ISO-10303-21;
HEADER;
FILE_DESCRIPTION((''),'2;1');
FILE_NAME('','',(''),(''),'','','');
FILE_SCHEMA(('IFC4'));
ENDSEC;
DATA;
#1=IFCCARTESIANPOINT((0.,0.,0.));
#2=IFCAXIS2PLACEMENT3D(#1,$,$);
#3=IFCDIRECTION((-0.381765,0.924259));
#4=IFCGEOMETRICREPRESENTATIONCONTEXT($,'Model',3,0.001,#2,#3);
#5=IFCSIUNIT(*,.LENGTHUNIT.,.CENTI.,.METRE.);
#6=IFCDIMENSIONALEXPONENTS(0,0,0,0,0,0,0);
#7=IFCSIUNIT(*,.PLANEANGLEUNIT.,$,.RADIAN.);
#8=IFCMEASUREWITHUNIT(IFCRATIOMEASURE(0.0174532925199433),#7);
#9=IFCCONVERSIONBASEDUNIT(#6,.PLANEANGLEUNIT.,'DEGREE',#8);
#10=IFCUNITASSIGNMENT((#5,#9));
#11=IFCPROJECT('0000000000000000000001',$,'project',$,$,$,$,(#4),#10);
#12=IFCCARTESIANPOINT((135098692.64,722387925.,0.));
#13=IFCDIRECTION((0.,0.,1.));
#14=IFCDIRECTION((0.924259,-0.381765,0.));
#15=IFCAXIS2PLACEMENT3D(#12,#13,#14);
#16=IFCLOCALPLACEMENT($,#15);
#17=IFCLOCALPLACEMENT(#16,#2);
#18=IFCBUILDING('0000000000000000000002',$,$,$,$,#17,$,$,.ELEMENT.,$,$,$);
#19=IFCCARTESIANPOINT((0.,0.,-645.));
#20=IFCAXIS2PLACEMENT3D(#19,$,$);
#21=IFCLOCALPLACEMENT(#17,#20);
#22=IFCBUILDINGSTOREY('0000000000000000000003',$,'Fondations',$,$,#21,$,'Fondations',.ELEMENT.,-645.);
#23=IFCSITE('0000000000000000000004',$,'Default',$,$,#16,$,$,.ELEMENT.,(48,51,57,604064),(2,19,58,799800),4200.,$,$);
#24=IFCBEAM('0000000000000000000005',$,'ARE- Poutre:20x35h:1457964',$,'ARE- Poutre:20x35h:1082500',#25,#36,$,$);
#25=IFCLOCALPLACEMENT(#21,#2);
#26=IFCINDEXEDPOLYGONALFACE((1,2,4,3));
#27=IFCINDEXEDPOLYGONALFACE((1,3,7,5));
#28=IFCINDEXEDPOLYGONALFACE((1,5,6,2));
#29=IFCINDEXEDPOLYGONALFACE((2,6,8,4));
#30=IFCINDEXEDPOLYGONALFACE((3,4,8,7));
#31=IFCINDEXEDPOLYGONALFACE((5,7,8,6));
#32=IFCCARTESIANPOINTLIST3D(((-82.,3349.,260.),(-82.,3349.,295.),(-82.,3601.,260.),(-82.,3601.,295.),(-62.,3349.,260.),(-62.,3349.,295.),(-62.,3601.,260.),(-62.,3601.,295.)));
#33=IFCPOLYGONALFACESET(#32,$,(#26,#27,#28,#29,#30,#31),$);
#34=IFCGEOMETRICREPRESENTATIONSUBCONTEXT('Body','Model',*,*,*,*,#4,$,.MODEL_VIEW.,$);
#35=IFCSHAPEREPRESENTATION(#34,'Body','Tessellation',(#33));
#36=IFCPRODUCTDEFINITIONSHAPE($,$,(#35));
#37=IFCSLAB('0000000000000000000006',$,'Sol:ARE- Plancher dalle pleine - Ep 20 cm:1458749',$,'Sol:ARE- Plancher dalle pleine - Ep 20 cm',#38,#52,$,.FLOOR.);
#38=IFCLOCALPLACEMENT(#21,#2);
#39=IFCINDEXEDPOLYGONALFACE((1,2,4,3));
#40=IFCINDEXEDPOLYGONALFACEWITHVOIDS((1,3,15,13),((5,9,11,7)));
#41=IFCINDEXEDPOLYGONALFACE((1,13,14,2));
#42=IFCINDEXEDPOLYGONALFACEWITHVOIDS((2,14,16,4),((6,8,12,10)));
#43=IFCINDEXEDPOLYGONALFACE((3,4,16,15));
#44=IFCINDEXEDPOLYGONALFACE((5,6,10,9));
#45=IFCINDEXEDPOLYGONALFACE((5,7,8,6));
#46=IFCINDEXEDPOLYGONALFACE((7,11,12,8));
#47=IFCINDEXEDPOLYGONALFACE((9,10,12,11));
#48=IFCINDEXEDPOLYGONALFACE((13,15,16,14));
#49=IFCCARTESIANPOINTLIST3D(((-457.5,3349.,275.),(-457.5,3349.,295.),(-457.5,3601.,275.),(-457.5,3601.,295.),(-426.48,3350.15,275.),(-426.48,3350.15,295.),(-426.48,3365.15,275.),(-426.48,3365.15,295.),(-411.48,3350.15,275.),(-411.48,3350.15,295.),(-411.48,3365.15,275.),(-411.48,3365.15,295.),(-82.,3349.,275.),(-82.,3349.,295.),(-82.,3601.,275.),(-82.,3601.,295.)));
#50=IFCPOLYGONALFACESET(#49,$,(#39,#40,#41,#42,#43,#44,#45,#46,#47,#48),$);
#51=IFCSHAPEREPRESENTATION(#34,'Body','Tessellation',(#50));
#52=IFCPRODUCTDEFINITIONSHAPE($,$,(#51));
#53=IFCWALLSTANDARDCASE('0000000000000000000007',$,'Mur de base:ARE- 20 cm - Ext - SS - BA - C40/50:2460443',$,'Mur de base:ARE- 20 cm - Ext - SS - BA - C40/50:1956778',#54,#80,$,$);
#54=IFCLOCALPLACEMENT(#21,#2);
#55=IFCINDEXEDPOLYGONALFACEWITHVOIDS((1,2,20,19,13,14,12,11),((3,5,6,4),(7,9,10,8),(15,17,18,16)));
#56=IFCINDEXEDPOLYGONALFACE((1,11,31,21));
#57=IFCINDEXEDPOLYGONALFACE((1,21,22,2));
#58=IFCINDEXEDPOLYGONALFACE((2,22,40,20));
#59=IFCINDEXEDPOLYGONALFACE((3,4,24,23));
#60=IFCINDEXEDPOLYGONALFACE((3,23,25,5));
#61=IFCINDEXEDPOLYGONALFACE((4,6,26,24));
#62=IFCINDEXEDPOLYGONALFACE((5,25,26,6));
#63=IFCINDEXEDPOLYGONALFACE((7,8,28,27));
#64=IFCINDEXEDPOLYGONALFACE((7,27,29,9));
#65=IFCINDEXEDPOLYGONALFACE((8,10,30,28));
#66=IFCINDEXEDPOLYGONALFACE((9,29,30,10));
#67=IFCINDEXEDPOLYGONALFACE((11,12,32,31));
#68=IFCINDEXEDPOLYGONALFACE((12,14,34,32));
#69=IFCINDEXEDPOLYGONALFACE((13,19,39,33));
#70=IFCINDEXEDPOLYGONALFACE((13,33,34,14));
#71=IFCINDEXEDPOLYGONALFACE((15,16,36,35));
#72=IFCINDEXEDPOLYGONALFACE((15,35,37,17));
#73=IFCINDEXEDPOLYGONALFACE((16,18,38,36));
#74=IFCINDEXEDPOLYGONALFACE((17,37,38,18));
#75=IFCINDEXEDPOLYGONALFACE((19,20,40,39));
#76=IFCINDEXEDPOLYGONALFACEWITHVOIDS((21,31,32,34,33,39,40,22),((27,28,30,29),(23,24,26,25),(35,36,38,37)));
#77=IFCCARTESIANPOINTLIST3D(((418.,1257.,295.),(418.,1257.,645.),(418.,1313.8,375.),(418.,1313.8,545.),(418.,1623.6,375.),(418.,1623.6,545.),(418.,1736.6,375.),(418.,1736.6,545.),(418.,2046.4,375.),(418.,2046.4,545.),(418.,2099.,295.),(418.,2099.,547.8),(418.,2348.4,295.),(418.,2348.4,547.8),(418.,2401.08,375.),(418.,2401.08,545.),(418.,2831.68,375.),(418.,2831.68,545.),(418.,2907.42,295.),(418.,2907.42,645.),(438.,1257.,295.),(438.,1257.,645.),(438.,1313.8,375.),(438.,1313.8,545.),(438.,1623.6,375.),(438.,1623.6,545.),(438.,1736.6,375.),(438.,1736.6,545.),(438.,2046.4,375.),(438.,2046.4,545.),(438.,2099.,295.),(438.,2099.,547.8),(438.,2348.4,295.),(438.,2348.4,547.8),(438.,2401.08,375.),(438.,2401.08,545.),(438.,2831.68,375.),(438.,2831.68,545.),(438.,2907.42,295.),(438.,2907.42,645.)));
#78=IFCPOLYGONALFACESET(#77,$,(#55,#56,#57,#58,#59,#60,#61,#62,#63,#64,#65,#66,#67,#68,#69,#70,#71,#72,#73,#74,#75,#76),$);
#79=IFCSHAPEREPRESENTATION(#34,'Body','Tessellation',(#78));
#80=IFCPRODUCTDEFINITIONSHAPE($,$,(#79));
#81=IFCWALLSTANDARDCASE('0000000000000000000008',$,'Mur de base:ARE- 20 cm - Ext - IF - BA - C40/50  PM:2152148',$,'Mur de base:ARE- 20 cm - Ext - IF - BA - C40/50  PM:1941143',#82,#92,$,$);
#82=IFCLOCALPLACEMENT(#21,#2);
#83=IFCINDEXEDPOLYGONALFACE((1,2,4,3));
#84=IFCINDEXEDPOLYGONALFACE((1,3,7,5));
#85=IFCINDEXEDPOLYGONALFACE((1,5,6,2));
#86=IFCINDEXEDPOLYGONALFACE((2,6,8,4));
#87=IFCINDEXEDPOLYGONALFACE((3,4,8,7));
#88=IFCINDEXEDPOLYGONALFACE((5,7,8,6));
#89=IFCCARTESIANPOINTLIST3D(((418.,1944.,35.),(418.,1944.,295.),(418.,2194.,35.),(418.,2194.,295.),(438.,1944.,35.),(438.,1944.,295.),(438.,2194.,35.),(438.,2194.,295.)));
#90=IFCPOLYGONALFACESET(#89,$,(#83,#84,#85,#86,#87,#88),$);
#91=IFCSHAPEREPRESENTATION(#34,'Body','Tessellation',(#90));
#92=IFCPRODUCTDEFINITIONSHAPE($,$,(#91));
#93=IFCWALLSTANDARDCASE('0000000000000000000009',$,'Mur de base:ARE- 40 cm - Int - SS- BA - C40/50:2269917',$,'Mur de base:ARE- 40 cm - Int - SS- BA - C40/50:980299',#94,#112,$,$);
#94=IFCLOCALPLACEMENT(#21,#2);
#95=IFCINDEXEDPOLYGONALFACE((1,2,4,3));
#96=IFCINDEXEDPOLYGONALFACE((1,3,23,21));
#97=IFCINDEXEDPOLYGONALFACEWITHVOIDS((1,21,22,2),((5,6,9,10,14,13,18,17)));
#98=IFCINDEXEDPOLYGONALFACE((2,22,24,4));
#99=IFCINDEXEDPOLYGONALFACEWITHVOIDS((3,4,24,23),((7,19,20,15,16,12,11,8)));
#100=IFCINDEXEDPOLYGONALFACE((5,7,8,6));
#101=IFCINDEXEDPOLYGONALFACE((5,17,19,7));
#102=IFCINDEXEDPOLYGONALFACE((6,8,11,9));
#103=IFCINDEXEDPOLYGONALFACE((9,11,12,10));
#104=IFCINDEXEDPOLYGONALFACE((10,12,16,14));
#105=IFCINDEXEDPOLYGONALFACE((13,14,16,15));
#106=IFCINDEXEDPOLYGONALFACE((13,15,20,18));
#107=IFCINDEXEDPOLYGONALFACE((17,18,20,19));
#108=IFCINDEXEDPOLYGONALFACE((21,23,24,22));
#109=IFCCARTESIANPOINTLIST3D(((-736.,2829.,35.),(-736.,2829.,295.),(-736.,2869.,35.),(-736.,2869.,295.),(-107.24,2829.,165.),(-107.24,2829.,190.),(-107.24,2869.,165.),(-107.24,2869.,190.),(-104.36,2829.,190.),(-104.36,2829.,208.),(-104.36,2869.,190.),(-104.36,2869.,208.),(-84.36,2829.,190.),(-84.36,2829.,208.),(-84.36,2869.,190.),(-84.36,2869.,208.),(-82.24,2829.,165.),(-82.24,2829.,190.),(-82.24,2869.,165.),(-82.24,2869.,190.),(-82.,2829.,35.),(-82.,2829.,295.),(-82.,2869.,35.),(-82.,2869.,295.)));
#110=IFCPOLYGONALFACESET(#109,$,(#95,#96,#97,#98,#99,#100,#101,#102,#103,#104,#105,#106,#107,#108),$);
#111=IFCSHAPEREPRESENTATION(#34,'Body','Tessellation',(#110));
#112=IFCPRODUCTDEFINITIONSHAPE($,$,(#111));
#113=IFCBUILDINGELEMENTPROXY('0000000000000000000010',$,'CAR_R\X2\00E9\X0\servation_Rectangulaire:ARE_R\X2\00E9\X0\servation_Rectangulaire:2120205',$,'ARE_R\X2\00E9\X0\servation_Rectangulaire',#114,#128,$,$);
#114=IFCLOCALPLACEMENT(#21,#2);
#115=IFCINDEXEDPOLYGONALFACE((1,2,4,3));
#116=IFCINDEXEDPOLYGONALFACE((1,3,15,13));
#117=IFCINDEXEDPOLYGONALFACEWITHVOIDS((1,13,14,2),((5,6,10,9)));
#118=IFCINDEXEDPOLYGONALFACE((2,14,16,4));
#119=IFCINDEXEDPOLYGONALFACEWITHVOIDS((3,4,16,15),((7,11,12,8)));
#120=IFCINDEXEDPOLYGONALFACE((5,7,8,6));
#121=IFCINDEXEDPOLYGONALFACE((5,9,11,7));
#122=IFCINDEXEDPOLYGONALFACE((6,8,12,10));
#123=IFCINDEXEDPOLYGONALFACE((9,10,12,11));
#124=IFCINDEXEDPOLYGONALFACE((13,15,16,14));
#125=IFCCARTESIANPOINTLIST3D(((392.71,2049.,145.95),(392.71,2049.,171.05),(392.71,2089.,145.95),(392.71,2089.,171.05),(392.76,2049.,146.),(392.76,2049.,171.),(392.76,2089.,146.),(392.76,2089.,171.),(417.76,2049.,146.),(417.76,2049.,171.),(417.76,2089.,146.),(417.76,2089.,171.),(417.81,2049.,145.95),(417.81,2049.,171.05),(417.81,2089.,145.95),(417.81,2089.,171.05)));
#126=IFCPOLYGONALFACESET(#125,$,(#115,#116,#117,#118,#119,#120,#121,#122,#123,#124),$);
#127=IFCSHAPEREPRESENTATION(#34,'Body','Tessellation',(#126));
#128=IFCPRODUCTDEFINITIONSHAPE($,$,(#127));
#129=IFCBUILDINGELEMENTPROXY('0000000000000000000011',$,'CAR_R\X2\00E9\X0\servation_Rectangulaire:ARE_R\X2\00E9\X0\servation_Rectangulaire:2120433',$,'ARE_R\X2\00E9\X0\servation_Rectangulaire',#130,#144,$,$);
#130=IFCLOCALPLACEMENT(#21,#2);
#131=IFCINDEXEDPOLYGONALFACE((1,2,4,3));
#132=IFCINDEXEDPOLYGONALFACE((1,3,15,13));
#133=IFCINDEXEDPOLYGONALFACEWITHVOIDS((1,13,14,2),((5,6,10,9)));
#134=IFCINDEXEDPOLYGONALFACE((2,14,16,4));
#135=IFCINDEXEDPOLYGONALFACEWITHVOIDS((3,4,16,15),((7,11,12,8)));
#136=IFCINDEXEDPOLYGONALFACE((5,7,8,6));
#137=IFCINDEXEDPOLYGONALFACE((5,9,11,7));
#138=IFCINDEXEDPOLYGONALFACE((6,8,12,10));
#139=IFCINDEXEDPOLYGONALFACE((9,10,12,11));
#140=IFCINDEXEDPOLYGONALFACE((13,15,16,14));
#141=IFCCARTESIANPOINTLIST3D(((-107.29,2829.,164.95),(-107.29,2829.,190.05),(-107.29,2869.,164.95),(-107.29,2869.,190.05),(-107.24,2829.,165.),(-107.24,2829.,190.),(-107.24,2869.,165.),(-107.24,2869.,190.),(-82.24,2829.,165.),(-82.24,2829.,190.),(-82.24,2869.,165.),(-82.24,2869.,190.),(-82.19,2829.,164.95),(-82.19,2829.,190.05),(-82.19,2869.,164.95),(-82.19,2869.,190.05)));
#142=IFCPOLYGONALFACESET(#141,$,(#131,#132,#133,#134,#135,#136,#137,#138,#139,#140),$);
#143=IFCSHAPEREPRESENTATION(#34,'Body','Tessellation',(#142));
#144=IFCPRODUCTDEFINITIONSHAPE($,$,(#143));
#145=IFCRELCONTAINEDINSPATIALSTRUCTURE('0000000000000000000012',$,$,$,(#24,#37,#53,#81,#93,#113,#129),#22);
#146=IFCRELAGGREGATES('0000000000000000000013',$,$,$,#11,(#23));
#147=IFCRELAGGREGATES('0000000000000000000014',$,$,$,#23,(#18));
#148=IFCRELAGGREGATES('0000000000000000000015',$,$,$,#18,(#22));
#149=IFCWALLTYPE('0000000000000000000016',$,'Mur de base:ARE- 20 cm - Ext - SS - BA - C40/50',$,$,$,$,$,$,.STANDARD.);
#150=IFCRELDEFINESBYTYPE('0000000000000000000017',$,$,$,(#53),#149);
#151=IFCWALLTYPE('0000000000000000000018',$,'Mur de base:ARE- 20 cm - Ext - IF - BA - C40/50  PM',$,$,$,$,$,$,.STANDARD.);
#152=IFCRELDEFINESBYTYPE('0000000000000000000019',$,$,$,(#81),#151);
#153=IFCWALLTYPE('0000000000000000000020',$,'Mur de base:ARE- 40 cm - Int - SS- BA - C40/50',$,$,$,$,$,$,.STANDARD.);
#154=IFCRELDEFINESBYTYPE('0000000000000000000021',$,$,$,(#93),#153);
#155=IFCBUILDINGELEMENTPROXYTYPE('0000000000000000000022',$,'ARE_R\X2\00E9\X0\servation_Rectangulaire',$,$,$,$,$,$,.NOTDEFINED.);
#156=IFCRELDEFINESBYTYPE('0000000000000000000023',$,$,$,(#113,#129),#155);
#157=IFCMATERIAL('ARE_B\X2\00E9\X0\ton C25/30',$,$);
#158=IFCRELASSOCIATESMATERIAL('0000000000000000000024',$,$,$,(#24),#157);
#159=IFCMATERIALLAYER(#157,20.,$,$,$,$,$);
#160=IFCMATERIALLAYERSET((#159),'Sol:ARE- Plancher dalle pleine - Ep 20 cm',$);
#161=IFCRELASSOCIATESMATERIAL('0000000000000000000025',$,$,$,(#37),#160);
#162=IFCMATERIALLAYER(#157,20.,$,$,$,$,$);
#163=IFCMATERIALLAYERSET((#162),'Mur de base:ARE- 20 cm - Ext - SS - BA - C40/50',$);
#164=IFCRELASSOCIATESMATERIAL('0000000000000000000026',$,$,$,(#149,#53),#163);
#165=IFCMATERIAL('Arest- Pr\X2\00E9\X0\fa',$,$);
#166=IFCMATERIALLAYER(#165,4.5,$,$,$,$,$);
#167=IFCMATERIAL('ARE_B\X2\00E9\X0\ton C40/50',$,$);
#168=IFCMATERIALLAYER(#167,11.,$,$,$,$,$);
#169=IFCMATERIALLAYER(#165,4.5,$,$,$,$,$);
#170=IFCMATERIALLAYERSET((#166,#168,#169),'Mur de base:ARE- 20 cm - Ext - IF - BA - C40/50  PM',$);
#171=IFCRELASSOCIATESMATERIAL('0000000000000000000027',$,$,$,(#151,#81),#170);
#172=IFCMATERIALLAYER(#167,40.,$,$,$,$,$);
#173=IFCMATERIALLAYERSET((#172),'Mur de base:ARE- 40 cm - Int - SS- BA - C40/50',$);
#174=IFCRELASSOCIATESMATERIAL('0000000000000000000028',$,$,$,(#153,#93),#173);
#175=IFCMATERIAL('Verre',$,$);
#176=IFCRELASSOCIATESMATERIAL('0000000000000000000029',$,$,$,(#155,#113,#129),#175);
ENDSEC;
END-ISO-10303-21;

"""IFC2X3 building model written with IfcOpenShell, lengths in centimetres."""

from ifc_helpers import new_model, entity, si_unit, converted_unit, direction, frame, frame_2d, origin, origin_2d_with_axis, place, context, subcontext, project, spatial, polyline, rectangle, outline, extrude, source, transform, mapped, material, layer, layer_set, layer_usage, type_object, type_shapes, element, save


model = new_model("IFC2X3")

# Units and contexts
model_context = context("Model", 3, precision=0.001, world=origin(), true_north=direction((-0.381765, 0.924259)))
body_context = subcontext(model_context, "Body", "Model", "MODEL_VIEW")
ifc_project = project(units=[si_unit("LENGTHUNIT", "METRE", prefix="CENTI"), converted_unit("PLANEANGLEUNIT", "DEGREE", entity("IfcRatioMeasure", 0.0174532925199433), si_unit("PLANEANGLEUNIT", "RADIAN"), dimensions=[0, 0, 0, 0, 0, 0, 0])], contexts=[model_context])

# Site, building, storey
site_placement = place(None, frame((135098692.64, 722387925.0, 0.0), z_axis=(0.0, 0.0, 1.0), x_axis=(0.924259, -0.381765, 0.0)))
site = spatial("IfcSite", under=ifc_project, at=site_placement, Name="Default", CompositionType="ELEMENT", RefLatitude=(48, 51, 57, 604064), RefLongitude=(2, 19, 58, 799800), RefElevation=4200.0)
building_placement = place(site_placement, origin())
building = spatial("IfcBuilding", under=site, at=building_placement, CompositionType="ELEMENT")
storey_placement = place(building_placement, frame((0.0, 0.0, -645.0)))
storey = spatial("IfcBuildingStorey", under=building, at=storey_placement, Name="Fondations", LongName="Fondations", CompositionType="ELEMENT", Elevation=-645.0)

# Beam
ifc_material_1 = material(Name="ARE_Béton C25/30")
beam_placement = place(storey_placement, frame((-72.0, 3339.0, 295.0), z_axis=(0.0, 0.0, 1.0), x_axis=(0.0, 1.0, 0.0)))
element("IfcBeam", 1, at=beam_placement, inside=storey, material=ifc_material_1, Name="ARE- Poutre:20x35h:1457964", ObjectType="ARE- Poutre:20x35h:1082500", context=body_context, shape_type="SweptSolid", body=[
    extrude(rectangle(XDim=35.0, YDim=20.0, at=frame_2d((0.0, 0.0), x_axis=(1.0, 0.0))), frame((10.0, 0.0, -17.5), z_axis=(1.0, 0.0, 0.0), x_axis=(0.0, 0.0, -1.0)), (0.0, 0.0, 1.0), 252.0),
])

# Slab, opening
ifc_layer_1 = layer(ifc_material_1, 20.0)
ifc_layer_set_1 = layer_set([ifc_layer_1], Name="Sol:ARE- Plancher dalle pleine - Ep 20 cm")
ifc_layer_usage_1 = layer_usage(ifc_layer_set_1, "AXIS3", "POSITIVE", 0.0)
slab_placement = place(storey_placement, frame((-457.5, 3349.0, 275.0)))
slab = element("IfcSlab", 2, at=slab_placement, inside=storey, material=ifc_layer_usage_1, Name="Sol:ARE- Plancher dalle pleine - Ep 20 cm:1458749", ObjectType="Sol:ARE- Plancher dalle pleine - Ep 20 cm", PredefinedType="FLOOR", context=body_context, shape_type="SweptSolid", body=[
    extrude(rectangle(XDim=375.5, YDim=252.0, at=origin_2d_with_axis()), frame((187.75, 126.0, 20.0), z_axis=(0.0, 0.0, -1.0), x_axis=(-1.0, 0.0, 0.0)), (0.0, 0.0, 1.0), 20.0),
])
opening_1_placement = place(slab_placement, origin())
element("IfcOpeningElement", 3, at=opening_1_placement, cuts=slab, ObjectType="Opening", context=body_context, shape_type="SweptSolid", body=[
    extrude(rectangle(XDim=15.0, YDim=15.0, at=origin_2d_with_axis()), frame((38.52, 8.65, 0.0), z_axis=(0.0, 0.0, 1.0), x_axis=(-1.0, 0.0, 0.0)), (0.0, 0.0, 1.0), 20.0),
])

# Shared definitions
ifc_material_2 = material(Name="ARE_Béton C40/50")

# Wall, openings
ifc_layer_2 = layer(ifc_material_1, 20.0)
ifc_layer_set_2 = layer_set([ifc_layer_2], Name="Mur de base:ARE- 20 cm - Ext - SS - BA - C40/50")
ifc_layer_usage_2 = layer_usage(ifc_layer_set_2, "AXIS2", "NEGATIVE", 10.0)
wall_type_1 = type_object("IfcWallType", Name="Mur de base:ARE- 20 cm - Ext - SS - BA - C40/50", PredefinedType="STANDARD", material=ifc_layer_set_2)
wall_1_placement = place(storey_placement, frame((428.0, 2907.42, 295.0), z_axis=(0.0, 0.0, 1.0), x_axis=(0.0, -1.0, 0.0)))
wall_1 = element("IfcWallStandardCase", 4, at=wall_1_placement, inside=storey, type_object=wall_type_1, material=ifc_layer_usage_2, Name="Mur de base:ARE- 20 cm - Ext - SS - BA - C40/50:2460443", ObjectType="Mur de base:ARE- 20 cm - Ext - SS - BA - C40/50:1956778", context=body_context, shape_type="SweptSolid", body=[
    extrude(rectangle(XDim=1650.42, YDim=20.0, at=frame_2d((825.21, 0.0), x_axis=(-1.0, 0.0))), origin(), (0.0, 0.0, 1.0), 350.0),
])
opening_2_placement = place(wall_1_placement, frame((2907.42, -428.0, -295.0), z_axis=(0.0, 0.0, 1.0), x_axis=(0.0, 1.0, 0.0)))
element("IfcOpeningElement", 5, at=opening_2_placement, cuts=wall_1, ObjectType="Opening", context=body_context, shape_type="SweptSolid", body=[
    extrude(rectangle(XDim=252.8, YDim=249.4, at=frame_2d((0.0, 0.0), x_axis=(1.0, 0.0))), frame((285.6, 2223.7, 421.4), z_axis=(1.0, 0.0, 0.0), x_axis=(0.0, 0.0, -1.0)), (0.0, 0.0, 1.0), 304.8),
])
opening_3_placement = place(wall_1_placement, frame((2907.42, -428.0, -295.0), z_axis=(0.0, 0.0, 1.0), x_axis=(0.0, 1.0, 0.0)))
element("IfcOpeningElement", 6, at=opening_3_placement, cuts=wall_1, ObjectType="Opening", context=body_context, shape_type="SweptSolid", body=[
    extrude(rectangle(XDim=170.0, YDim=309.8, at=frame_2d((0.0, 0.0), x_axis=(0.0, 1.0))), frame((265.6, 1468.7, 460.0), z_axis=(1.0, 0.0, 0.0), x_axis=(0.0, -1.0, 0.0)), (0.0, 0.0, 1.0), 304.8),
])
opening_4_placement = place(wall_1_placement, frame((2907.42, -428.0, -295.0), z_axis=(0.0, 0.0, 1.0), x_axis=(0.0, 1.0, 0.0)))
element("IfcOpeningElement", 7, at=opening_4_placement, cuts=wall_1, ObjectType="Opening", context=body_context, shape_type="SweptSolid", body=[
    extrude(rectangle(XDim=170.0, YDim=309.8, at=frame_2d((0.0, 0.0), x_axis=(0.0, 1.0))), frame((265.6, 1891.5, 460.0), z_axis=(1.0, 0.0, 0.0), x_axis=(0.0, -1.0, 0.0)), (0.0, 0.0, 1.0), 304.8),
])
opening_5_placement = place(wall_1_placement, frame((2907.42, -428.0, -295.0), z_axis=(0.0, 0.0, 1.0), x_axis=(0.0, 1.0, 0.0)))
element("IfcOpeningElement", 8, at=opening_5_placement, cuts=wall_1, ObjectType="Opening", context=body_context, shape_type="SweptSolid", body=[
    extrude(rectangle(XDim=170.0, YDim=430.6, at=frame_2d((0.0, 0.0), x_axis=(0.0, 1.0))), frame((265.6, 2616.38, 460.0), z_axis=(1.0, 0.0, 0.0), x_axis=(0.0, -1.0, 0.0)), (0.0, 0.0, 1.0), 304.8),
])

# Wall
ifc_material_3 = material(Name="Arest- Préfa")
ifc_layer_3 = layer(ifc_material_3, 4.5)
ifc_layer_4 = layer(ifc_material_2, 11.0)
ifc_layer_5 = layer(ifc_material_3, 4.5)
ifc_layer_set_3 = layer_set([ifc_layer_3, ifc_layer_4, ifc_layer_5], Name="Mur de base:ARE- 20 cm - Ext - IF - BA - C40/50  PM")
ifc_layer_usage_3 = layer_usage(ifc_layer_set_3, "AXIS2", "NEGATIVE", 10.0)
wall_type_2 = type_object("IfcWallType", Name="Mur de base:ARE- 20 cm - Ext - IF - BA - C40/50  PM", PredefinedType="STANDARD", material=ifc_layer_set_3)
wall_2_placement = place(storey_placement, frame((428.0, 1944.0, 35.0), z_axis=(0.0, 0.0, 1.0), x_axis=(0.0, 1.0, 0.0)))
element("IfcWallStandardCase", 9, at=wall_2_placement, inside=storey, type_object=wall_type_2, material=ifc_layer_usage_3, Name="Mur de base:ARE- 20 cm - Ext - IF - BA - C40/50  PM:2152148", ObjectType="Mur de base:ARE- 20 cm - Ext - IF - BA - C40/50  PM:1941143", context=body_context, shape_type="SweptSolid", body=[
    extrude(rectangle(XDim=250.0, YDim=20.0, at=frame_2d((125.0, 0.0), x_axis=(-1.0, 0.0))), origin(), (0.0, 0.0, 1.0), 260.0),
])

# Shared definitions
ifc_layer_6 = layer(ifc_material_2, 40.0)
ifc_layer_set_4 = layer_set([ifc_layer_6], Name="Mur de base:ARE- 40 cm - Int - SS- BA - C40/50")
wall_type_3 = type_object("IfcWallType", Name="Mur de base:ARE- 40 cm - Int - SS- BA - C40/50", PredefinedType="STANDARD", material=ifc_layer_set_4)

# Wall, openings
ifc_layer_usage_4 = layer_usage(ifc_layer_set_4, "AXIS2", "NEGATIVE", 20.0)
wall_3_placement = place(storey_placement, frame((-82.0, 2849.0, 35.0), z_axis=(0.0, 0.0, 1.0), x_axis=(-1.0, 0.0, 0.0)))
wall_3 = element("IfcWallStandardCase", 10, at=wall_3_placement, inside=storey, type_object=wall_type_3, material=ifc_layer_usage_4, Name="Mur de base:ARE- 40 cm - Int - SS- BA - C40/50:2269917", ObjectType="Mur de base:ARE- 40 cm - Int - SS- BA - C40/50:980299", context=body_context, shape_type="SweptSolid", body=[
    extrude(rectangle(XDim=654.0, YDim=40.0, at=frame_2d((327.0, 0.0), x_axis=(-1.0, 0.0))), origin(), (0.0, 0.0, 1.0), 260.0),
])
opening_6_placement = place(wall_3_placement, origin())
element("IfcOpeningElement", 11, at=opening_6_placement, cuts=wall_3, ObjectType="Opening", context=body_context, shape_type="SweptSolid", body=[
    extrude(rectangle(XDim=25.0, YDim=25.0, at=frame_2d((0.0, 0.0), x_axis=(1.0, 0.0))), frame((12.74, -20.0, 142.5), z_axis=(0.0, 1.0, 0.0), x_axis=(0.0, 0.0, -1.0)), (0.0, 0.0, 1.0), 40.0),
])
opening_7_placement = place(wall_3_placement, origin())
element("IfcOpeningElement", 12, at=opening_7_placement, cuts=wall_3, ObjectType="Opening", context=body_context, shape_type="SweptSolid", body=[
    extrude(rectangle(XDim=20.0, YDim=20.0, at=origin_2d_with_axis()), frame((12.36, -20.0, 163.0), z_axis=(0.0, 1.0, 0.0), x_axis=(0.0, 0.0, -1.0)), (0.0, 0.0, 1.0), 40.0),
])

# Building element proxies
ifc_material_4 = material(Name="Verre")
building_element_proxy_type_1 = type_object("IfcBuildingElementProxyType", Name="ARE_Réservation_Rectangulaire", PredefinedType="NOTDEFINED", material=ifc_material_4)
shared_shape_1 = source(origin(), body_context, "Body", "SweptSolid", [
    extrude(outline(polyline([(-12.55, -12.55), (12.55, -12.55), (12.55, 12.55), (-12.55, 12.55), (-12.55, -12.55)]), holes=[polyline([(12.5, -12.5), (-12.5, -12.5), (-12.5, 12.5), (12.5, 12.5), (12.5, -12.5)])]), frame((0.0, 0.0, -40.0), z_axis=(0.0, 0.0, 1.0), x_axis=(-1.0, 0.0, 0.0)), (0.0, 0.0, 1.0), 40.0),
])
type_shapes(building_element_proxy_type_1, [shared_shape_1])
for number, where, z_axis, x_axis, name in (
    (13, (405.26, 2049.0, 158.5), (0.0, -1.0, 0.0), (1.0, 0.0, 0.0), "CAR_Réservation_Rectangulaire:ARE_Réservation_Rectangulaire:2120205"),
    (14, (-94.74, 2869.0, 177.5), (0.0, 1.0, 0.0), (-1.0, 0.0, 0.0), "CAR_Réservation_Rectangulaire:ARE_Réservation_Rectangulaire:2120433"),
):
    element("IfcBuildingElementProxy", number, at=place(storey_placement, frame(where, z_axis=z_axis, x_axis=x_axis)), inside=storey, type_object=building_element_proxy_type_1, material=ifc_material_4, Name=name, ObjectType="ARE_Réservation_Rectangulaire", context=body_context, shape_type="MappedRepresentation", body=[
        mapped(shared_shape_1, transform((0.0, 0.0, 0.0), scale=1.0)),
    ])

save(model, "model.ifc")
